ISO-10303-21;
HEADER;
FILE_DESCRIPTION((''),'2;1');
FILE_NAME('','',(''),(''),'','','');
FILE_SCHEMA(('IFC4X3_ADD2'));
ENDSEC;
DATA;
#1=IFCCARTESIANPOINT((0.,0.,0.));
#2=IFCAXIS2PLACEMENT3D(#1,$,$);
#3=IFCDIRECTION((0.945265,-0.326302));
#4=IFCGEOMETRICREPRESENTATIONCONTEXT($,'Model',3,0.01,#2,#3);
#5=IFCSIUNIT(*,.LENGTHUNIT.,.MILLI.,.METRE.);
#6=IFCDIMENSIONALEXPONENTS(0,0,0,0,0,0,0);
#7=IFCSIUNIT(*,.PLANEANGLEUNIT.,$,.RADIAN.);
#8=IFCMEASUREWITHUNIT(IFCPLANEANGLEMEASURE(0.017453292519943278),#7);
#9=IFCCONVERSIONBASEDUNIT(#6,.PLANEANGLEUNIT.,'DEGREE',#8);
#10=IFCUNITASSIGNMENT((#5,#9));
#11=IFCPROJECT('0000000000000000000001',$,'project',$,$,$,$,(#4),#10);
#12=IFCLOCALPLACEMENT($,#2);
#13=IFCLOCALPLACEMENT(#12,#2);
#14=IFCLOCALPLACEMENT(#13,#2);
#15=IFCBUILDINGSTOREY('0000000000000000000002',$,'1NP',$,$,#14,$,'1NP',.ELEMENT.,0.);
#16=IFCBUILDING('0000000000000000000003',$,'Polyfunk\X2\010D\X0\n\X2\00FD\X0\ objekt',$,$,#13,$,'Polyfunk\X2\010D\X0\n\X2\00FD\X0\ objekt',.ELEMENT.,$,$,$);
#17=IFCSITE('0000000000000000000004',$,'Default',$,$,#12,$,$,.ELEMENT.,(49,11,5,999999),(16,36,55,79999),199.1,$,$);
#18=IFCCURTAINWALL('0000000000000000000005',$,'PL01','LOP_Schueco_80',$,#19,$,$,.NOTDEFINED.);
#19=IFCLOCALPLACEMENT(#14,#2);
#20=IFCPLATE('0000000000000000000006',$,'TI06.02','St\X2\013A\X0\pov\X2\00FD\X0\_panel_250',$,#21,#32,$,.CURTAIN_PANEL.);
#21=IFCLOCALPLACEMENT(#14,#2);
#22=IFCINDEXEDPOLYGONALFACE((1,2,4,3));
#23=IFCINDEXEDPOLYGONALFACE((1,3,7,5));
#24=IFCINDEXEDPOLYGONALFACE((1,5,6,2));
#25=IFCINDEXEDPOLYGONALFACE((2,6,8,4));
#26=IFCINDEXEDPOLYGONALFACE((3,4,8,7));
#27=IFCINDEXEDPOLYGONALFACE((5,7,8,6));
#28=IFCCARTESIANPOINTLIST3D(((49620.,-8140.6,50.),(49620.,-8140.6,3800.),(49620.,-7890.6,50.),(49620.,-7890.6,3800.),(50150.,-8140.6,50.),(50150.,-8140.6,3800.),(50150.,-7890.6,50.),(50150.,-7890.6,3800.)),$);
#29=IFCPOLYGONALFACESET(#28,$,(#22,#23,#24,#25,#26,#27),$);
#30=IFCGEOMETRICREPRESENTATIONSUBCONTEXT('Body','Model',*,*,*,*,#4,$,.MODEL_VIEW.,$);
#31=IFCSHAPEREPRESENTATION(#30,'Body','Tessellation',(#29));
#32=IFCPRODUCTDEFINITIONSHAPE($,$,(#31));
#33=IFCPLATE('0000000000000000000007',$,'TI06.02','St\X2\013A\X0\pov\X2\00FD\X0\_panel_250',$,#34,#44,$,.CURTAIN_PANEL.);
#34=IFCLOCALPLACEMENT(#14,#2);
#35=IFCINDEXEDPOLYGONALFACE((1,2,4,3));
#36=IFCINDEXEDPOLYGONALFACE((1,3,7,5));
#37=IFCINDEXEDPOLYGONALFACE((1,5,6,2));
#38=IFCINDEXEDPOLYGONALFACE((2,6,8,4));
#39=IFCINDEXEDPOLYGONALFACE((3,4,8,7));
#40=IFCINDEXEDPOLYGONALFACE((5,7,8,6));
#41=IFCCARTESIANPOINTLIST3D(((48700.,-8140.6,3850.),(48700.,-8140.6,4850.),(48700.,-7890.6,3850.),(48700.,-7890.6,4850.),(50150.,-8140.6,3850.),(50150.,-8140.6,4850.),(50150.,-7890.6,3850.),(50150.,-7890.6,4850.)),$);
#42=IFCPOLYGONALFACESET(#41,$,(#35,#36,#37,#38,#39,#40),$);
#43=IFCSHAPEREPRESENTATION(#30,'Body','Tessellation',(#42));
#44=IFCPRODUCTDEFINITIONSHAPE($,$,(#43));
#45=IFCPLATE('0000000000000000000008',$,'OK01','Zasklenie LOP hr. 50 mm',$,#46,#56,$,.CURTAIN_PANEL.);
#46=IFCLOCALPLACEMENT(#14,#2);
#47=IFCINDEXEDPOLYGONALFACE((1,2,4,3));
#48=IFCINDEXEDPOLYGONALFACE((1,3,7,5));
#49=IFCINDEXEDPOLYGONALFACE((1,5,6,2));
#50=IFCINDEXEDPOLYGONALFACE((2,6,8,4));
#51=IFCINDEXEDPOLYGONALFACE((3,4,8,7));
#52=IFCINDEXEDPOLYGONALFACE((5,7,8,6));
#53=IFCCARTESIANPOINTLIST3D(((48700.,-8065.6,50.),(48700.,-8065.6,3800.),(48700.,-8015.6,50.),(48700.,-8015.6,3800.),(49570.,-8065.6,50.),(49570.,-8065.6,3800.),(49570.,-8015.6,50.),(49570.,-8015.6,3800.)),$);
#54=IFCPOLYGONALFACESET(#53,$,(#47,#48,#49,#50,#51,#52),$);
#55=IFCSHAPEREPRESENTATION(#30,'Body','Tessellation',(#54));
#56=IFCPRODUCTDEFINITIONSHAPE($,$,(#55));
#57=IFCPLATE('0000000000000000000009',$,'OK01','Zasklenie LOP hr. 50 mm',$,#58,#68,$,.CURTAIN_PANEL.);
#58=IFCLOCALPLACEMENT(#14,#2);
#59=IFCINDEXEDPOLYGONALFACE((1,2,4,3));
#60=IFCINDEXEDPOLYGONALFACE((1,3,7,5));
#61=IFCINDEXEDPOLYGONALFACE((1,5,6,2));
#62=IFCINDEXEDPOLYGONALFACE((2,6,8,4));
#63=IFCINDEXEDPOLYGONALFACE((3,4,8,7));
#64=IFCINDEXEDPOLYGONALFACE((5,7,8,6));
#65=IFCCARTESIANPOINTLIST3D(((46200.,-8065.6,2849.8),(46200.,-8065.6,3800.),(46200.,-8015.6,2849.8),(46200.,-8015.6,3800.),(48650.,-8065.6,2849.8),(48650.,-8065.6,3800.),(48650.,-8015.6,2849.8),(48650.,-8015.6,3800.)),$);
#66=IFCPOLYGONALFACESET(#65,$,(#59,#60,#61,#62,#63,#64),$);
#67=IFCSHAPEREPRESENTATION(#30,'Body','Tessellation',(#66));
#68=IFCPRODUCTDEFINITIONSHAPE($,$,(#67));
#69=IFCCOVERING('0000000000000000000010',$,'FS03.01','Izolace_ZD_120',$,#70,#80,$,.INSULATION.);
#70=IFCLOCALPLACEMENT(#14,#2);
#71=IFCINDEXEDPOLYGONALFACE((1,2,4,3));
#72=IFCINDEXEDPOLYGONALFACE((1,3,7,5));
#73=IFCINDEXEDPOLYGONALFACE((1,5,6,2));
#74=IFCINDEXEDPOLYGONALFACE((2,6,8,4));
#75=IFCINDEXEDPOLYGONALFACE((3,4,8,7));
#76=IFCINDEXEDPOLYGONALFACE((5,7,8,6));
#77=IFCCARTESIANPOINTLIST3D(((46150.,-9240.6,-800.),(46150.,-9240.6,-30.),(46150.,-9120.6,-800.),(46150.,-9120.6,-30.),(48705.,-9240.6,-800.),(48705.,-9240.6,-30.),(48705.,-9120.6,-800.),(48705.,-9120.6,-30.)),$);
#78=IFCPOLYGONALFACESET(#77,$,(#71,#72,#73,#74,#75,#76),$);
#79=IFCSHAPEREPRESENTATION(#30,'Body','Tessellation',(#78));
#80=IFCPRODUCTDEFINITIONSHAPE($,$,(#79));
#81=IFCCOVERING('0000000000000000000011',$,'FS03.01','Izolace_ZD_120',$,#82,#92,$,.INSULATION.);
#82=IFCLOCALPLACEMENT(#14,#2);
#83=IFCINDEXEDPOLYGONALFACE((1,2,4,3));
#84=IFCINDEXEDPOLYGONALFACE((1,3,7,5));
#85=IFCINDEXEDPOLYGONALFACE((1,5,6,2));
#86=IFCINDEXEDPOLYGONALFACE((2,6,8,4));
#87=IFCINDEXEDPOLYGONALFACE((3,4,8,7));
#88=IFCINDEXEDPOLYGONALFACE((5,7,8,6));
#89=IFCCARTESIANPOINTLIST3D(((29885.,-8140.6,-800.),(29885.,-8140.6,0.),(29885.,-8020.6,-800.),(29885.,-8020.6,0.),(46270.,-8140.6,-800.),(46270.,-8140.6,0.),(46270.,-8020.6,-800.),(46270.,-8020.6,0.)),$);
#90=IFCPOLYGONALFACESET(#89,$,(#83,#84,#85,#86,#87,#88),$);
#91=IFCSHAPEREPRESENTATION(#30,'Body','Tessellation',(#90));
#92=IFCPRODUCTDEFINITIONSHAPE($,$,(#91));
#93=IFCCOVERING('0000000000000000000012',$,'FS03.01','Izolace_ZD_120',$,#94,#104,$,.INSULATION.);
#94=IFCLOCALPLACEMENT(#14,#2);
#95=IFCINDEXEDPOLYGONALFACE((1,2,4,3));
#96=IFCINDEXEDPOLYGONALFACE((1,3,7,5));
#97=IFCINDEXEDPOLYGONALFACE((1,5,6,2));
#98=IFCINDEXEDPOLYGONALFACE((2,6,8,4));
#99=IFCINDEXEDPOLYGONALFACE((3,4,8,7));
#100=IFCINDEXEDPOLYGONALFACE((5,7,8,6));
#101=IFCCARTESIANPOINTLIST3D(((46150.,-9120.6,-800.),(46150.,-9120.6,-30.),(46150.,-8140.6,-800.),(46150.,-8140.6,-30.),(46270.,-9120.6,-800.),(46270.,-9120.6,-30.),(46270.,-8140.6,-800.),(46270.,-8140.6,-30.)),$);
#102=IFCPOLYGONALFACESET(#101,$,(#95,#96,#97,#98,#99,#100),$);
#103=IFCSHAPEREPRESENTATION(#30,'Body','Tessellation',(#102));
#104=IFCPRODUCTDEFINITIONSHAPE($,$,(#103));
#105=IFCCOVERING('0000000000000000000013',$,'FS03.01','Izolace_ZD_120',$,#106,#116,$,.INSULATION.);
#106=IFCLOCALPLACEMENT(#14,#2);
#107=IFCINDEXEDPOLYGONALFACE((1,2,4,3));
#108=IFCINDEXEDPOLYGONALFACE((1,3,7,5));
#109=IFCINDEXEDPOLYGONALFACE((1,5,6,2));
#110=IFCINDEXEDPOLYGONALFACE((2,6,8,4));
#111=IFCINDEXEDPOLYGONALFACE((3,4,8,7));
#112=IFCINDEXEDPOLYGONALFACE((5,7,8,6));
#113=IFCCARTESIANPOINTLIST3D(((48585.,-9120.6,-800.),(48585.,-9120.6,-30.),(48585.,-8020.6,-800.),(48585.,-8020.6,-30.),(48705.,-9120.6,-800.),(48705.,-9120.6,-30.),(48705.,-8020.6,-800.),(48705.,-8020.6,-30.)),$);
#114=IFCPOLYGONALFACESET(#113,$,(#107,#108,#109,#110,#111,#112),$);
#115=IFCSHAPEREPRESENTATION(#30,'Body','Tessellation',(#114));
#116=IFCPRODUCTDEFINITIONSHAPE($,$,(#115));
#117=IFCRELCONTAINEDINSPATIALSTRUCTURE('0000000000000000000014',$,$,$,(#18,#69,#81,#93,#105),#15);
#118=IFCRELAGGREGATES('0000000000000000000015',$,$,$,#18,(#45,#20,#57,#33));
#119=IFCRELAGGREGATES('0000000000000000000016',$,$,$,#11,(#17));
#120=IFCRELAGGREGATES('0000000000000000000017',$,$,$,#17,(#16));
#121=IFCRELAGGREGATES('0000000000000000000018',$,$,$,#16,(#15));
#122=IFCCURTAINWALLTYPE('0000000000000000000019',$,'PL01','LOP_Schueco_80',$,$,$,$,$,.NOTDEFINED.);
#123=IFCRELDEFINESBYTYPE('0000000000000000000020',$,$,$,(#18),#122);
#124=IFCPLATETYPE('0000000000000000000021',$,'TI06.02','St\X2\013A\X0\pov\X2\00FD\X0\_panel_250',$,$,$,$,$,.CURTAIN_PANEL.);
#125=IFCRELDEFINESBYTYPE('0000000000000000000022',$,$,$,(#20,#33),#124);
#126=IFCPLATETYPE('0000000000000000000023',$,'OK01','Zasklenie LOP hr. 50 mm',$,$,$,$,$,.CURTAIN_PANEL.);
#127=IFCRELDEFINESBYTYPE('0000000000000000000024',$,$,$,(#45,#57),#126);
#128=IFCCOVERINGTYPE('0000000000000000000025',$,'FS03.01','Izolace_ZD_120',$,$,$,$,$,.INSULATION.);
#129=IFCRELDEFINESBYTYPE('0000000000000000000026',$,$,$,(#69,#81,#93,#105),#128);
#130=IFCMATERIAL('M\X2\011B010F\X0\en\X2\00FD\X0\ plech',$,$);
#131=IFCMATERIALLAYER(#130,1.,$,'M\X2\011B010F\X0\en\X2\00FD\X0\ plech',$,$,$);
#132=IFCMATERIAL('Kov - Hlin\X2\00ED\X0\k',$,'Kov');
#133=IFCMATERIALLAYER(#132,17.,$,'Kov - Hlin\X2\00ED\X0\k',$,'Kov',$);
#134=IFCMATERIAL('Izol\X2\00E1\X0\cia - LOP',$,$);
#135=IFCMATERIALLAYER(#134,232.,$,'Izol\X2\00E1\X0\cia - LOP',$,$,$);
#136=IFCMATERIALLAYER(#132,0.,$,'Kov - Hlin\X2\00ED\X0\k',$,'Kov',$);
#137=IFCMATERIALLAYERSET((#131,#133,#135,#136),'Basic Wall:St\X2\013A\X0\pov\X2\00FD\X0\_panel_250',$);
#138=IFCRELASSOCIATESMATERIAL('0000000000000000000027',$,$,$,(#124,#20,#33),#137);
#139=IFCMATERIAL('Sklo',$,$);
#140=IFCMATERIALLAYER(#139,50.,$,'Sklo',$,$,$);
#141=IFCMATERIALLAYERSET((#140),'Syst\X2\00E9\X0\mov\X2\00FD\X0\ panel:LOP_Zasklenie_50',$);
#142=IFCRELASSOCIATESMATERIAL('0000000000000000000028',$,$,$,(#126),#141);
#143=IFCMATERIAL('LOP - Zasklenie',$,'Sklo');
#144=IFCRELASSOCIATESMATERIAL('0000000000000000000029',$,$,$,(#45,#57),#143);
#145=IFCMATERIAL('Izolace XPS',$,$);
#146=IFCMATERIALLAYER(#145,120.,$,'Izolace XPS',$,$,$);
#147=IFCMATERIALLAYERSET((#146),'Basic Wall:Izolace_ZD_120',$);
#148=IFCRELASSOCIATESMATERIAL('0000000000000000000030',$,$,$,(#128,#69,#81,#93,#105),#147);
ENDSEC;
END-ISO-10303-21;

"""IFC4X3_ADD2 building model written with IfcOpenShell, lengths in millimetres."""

from ifc_helpers import new_model, entity, si_unit, converted_unit, direction, frame, frame_2d, origin, origin_2d_with_axis, place, context, subcontext, project, spatial, rectangle, extrude, source, transform, mapped, material, layer, layer_set, layer_usage, type_object, type_shapes, element, aggregate, save


model = new_model("IFC4X3_ADD2")

# Units and contexts
model_context = context("Model", 3, precision=0.01, world=origin(), true_north=direction((0.945265, -0.326302)))
body_context = subcontext(model_context, "Body", "Model", "MODEL_VIEW")
ifc_project = project(units=[si_unit("LENGTHUNIT", "METRE", prefix="MILLI"), converted_unit("PLANEANGLEUNIT", "DEGREE", entity("IfcPlaneAngleMeasure", 0.017453292519943278), si_unit("PLANEANGLEUNIT", "RADIAN"), dimensions=[0, 0, 0, 0, 0, 0, 0])], contexts=[model_context])

# Site, building, storey
site_placement = place(None, origin())
site = spatial("IfcSite", under=ifc_project, at=site_placement, Name="Default", CompositionType="ELEMENT", RefLatitude=(49, 11, 5, 999999), RefLongitude=(16, 36, 55, 79999), RefElevation=199.1)
building_placement = place(site_placement, origin())
building = spatial("IfcBuilding", under=site, at=building_placement, Name="Polyfunkčný objekt", LongName="Polyfunkčný objekt", CompositionType="ELEMENT")
storey_placement = place(building_placement, origin())
storey = spatial("IfcBuildingStorey", under=building, at=storey_placement, Name="1NP", LongName="1NP", CompositionType="ELEMENT", Elevation=0.0)

# Curtain wall, plates
curtain_wall_type = type_object("IfcCurtainWallType", Name="PL01", Description="LOP_Schueco_80", PredefinedType="NOTDEFINED")
curtain_wall_placement = place(storey_placement, origin())
curtain_wall = element("IfcCurtainWall", 1, at=curtain_wall_placement, inside=storey, type_object=curtain_wall_type, Name="PL01", Description="LOP_Schueco_80", PredefinedType="NOTDEFINED")
ifc_material_1 = material(Name="Měďený plech")
ifc_layer_1 = layer(ifc_material_1, 1.0, Name="Měďený plech")
ifc_material_2 = material(Name="Kov - Hliník", Category="Kov")
ifc_layer_2 = layer(ifc_material_2, 17.0, Name="Kov - Hliník", Category="Kov")
ifc_material_3 = material(Name="Izolácia - LOP")
ifc_layer_3 = layer(ifc_material_3, 232.0, Name="Izolácia - LOP")
ifc_layer_4 = layer(ifc_material_2, 0.0, Name="Kov - Hliník", Category="Kov")
ifc_layer_set_1 = layer_set([ifc_layer_1, ifc_layer_2, ifc_layer_3, ifc_layer_4], Name="Basic Wall:Stĺpový_panel_250")
ifc_layer_usage_1 = layer_usage(ifc_layer_set_1, "AXIS2", "POSITIVE", -125.0)
plate_type_1 = type_object("IfcPlateType", Name="TI06.02", Description="Stĺpový_panel_250", PredefinedType="CURTAIN_PANEL", material=ifc_layer_set_1)
plate_1_placement = place(storey_placement, frame((49620.0, -8015.6, 50.0)))
plate_1 = element("IfcPlate", 2, at=plate_1_placement, type_object=plate_type_1, material=ifc_layer_usage_1, Name="TI06.02", Description="Stĺpový_panel_250", PredefinedType="CURTAIN_PANEL", context=body_context, shape_type="SweptSolid", body=[
    extrude(rectangle(XDim=250.0, YDim=530.0, at=frame_2d((0.0, 0.0), x_axis=(1.0, 0.0))), frame((265.0, 0.0, 0.0), z_axis=(0.0, 0.0, 1.0), x_axis=(0.0, 1.0, 0.0)), (0.0, 0.0, 1.0), 3750.0),
])
ifc_layer_usage_2 = layer_usage(ifc_layer_set_1, "AXIS2", "POSITIVE", -125.0)
plate_2_placement = place(storey_placement, frame((48700.0, -8015.6, 3850.0)))
plate_2 = element("IfcPlate", 3, at=plate_2_placement, type_object=plate_type_1, material=ifc_layer_usage_2, Name="TI06.02", Description="Stĺpový_panel_250", PredefinedType="CURTAIN_PANEL", context=body_context, shape_type="SweptSolid", body=[
    extrude(rectangle(XDim=250.0, YDim=1450.0, at=frame_2d((0.0, 0.0), x_axis=(1.0, 0.0))), frame((725.0, 0.0, 0.0), z_axis=(0.0, 0.0, 1.0), x_axis=(0.0, 1.0, 0.0)), (0.0, 0.0, 1.0), 1000.0),
])
ifc_material_4 = material(Name="LOP - Zasklenie", Category="Sklo")
ifc_material_5 = material(Name="Sklo")
ifc_layer_5 = layer(ifc_material_5, 50.0, Name="Sklo")
ifc_layer_set_2 = layer_set([ifc_layer_5], Name="Systémový panel:LOP_Zasklenie_50")
plate_type_2 = type_object("IfcPlateType", Name="OK01", Description="Zasklenie LOP hr. 50 mm", PredefinedType="CURTAIN_PANEL", material=ifc_layer_set_2)
shared_shape_1 = source(origin(), body_context, "Body", "SweptSolid", [
    extrude(rectangle(XDim=3750.0, YDim=870.0, at=frame_2d((-331.2, 0.0), x_axis=(1.0, 0.0))), frame((0.0, -50.0, 2206.2), z_axis=(0.0, 1.0, 0.0), x_axis=(0.0, 0.0, 1.0)), (0.0, 0.0, 1.0), 50.0),
])
plate_3_placement = place(curtain_wall_placement, frame((49135.0, -8015.6, 50.0)))
plate_3 = element("IfcPlate", 4, at=plate_3_placement, type_object=plate_type_2, material=ifc_material_4, Name="OK01", Description="Zasklenie LOP hr. 50 mm", PredefinedType="CURTAIN_PANEL", context=body_context, shape_type="MappedRepresentation", body=[
    mapped(shared_shape_1, transform((0.0, 0.0, 0.0), scale=1.0)),
])
shared_shape_2 = source(origin(), body_context, "Body", "SweptSolid", [
    extrude(rectangle(XDim=50.0, YDim=2450.0, at=origin_2d_with_axis()), frame((0.0, -25.0, 0.0), z_axis=(0.0, 0.0, 1.0), x_axis=(0.0, 1.0, 0.0)), (0.0, 0.0, 1.0), 950.2),
])
type_shapes(plate_type_2, [shared_shape_1, shared_shape_2])
plate_4_placement = place(curtain_wall_placement, frame((47425.0, -8015.6, 2849.8)))
plate_4 = element("IfcPlate", 5, at=plate_4_placement, type_object=plate_type_2, material=ifc_material_4, Name="OK01", Description="Zasklenie LOP hr. 50 mm", PredefinedType="CURTAIN_PANEL", context=body_context, shape_type="MappedRepresentation", body=[
    mapped(shared_shape_2, transform((0.0, 0.0, 0.0), scale=1.0)),
])
aggregate(curtain_wall, [plate_3, plate_1, plate_4, plate_2])

# Coverings
ifc_material_6 = material(Name="Izolace XPS")
ifc_layer_6 = layer(ifc_material_6, 120.0, Name="Izolace XPS")
ifc_layer_set_3 = layer_set([ifc_layer_6], Name="Basic Wall:Izolace_ZD_120")
covering_type = type_object("IfcCoveringType", Name="FS03.01", Description="Izolace_ZD_120", PredefinedType="INSULATION", material=ifc_layer_set_3)
covering_1_placement = place(storey_placement, frame((48705.0, -9180.6, -800.0), z_axis=(0.0, 0.0, 1.0), x_axis=(-1.0, 0.0, 0.0)))
element("IfcCovering", 6, at=covering_1_placement, inside=storey, type_object=covering_type, material=ifc_layer_set_3, Name="FS03.01", Description="Izolace_ZD_120", PredefinedType="INSULATION", context=body_context, shape_type="SweptSolid", body=[
    extrude(rectangle(XDim=2555.0, YDim=120.0, at=frame_2d((1277.5, 0.0), x_axis=(-1.0, 0.0))), origin(), (0.0, 0.0, 1.0), 770.0),
])
covering_2_placement = place(storey_placement, frame((46270.0, -8080.6, -800.0), z_axis=(0.0, 0.0, 1.0), x_axis=(-1.0, 0.0, 0.0)))
element("IfcCovering", 7, at=covering_2_placement, inside=storey, type_object=covering_type, material=ifc_layer_set_3, Name="FS03.01", Description="Izolace_ZD_120", PredefinedType="INSULATION", context=body_context, shape_type="SweptSolid", body=[
    extrude(rectangle(XDim=16385.0, YDim=120.0, at=frame_2d((8192.5, 0.0), x_axis=(-1.0, 0.0))), origin(), (0.0, 0.0, 1.0), 800.0),
])
covering_3_placement = place(storey_placement, frame((46210.0, -9120.6, -800.0), z_axis=(0.0, 0.0, 1.0), x_axis=(0.0, 1.0, 0.0)))
element("IfcCovering", 8, at=covering_3_placement, inside=storey, type_object=covering_type, material=ifc_layer_set_3, Name="FS03.01", Description="Izolace_ZD_120", PredefinedType="INSULATION", context=body_context, shape_type="SweptSolid", body=[
    extrude(rectangle(XDim=980.0, YDim=120.0, at=frame_2d((490.0, 0.0), x_axis=(-1.0, 0.0))), origin(), (0.0, 0.0, 1.0), 770.0),
])
covering_4_placement = place(storey_placement, frame((48645.0, -9120.6, -800.0), z_axis=(0.0, 0.0, 1.0), x_axis=(0.0, 1.0, 0.0)))
element("IfcCovering", 9, at=covering_4_placement, inside=storey, type_object=covering_type, material=ifc_layer_set_3, Name="FS03.01", Description="Izolace_ZD_120", PredefinedType="INSULATION", context=body_context, shape_type="SweptSolid", body=[
    extrude(rectangle(XDim=1100.0, YDim=120.0, at=frame_2d((550.0, 0.0), x_axis=(-1.0, 0.0))), origin(), (0.0, 0.0, 1.0), 770.0),
])

save(model, "model.ifc")
